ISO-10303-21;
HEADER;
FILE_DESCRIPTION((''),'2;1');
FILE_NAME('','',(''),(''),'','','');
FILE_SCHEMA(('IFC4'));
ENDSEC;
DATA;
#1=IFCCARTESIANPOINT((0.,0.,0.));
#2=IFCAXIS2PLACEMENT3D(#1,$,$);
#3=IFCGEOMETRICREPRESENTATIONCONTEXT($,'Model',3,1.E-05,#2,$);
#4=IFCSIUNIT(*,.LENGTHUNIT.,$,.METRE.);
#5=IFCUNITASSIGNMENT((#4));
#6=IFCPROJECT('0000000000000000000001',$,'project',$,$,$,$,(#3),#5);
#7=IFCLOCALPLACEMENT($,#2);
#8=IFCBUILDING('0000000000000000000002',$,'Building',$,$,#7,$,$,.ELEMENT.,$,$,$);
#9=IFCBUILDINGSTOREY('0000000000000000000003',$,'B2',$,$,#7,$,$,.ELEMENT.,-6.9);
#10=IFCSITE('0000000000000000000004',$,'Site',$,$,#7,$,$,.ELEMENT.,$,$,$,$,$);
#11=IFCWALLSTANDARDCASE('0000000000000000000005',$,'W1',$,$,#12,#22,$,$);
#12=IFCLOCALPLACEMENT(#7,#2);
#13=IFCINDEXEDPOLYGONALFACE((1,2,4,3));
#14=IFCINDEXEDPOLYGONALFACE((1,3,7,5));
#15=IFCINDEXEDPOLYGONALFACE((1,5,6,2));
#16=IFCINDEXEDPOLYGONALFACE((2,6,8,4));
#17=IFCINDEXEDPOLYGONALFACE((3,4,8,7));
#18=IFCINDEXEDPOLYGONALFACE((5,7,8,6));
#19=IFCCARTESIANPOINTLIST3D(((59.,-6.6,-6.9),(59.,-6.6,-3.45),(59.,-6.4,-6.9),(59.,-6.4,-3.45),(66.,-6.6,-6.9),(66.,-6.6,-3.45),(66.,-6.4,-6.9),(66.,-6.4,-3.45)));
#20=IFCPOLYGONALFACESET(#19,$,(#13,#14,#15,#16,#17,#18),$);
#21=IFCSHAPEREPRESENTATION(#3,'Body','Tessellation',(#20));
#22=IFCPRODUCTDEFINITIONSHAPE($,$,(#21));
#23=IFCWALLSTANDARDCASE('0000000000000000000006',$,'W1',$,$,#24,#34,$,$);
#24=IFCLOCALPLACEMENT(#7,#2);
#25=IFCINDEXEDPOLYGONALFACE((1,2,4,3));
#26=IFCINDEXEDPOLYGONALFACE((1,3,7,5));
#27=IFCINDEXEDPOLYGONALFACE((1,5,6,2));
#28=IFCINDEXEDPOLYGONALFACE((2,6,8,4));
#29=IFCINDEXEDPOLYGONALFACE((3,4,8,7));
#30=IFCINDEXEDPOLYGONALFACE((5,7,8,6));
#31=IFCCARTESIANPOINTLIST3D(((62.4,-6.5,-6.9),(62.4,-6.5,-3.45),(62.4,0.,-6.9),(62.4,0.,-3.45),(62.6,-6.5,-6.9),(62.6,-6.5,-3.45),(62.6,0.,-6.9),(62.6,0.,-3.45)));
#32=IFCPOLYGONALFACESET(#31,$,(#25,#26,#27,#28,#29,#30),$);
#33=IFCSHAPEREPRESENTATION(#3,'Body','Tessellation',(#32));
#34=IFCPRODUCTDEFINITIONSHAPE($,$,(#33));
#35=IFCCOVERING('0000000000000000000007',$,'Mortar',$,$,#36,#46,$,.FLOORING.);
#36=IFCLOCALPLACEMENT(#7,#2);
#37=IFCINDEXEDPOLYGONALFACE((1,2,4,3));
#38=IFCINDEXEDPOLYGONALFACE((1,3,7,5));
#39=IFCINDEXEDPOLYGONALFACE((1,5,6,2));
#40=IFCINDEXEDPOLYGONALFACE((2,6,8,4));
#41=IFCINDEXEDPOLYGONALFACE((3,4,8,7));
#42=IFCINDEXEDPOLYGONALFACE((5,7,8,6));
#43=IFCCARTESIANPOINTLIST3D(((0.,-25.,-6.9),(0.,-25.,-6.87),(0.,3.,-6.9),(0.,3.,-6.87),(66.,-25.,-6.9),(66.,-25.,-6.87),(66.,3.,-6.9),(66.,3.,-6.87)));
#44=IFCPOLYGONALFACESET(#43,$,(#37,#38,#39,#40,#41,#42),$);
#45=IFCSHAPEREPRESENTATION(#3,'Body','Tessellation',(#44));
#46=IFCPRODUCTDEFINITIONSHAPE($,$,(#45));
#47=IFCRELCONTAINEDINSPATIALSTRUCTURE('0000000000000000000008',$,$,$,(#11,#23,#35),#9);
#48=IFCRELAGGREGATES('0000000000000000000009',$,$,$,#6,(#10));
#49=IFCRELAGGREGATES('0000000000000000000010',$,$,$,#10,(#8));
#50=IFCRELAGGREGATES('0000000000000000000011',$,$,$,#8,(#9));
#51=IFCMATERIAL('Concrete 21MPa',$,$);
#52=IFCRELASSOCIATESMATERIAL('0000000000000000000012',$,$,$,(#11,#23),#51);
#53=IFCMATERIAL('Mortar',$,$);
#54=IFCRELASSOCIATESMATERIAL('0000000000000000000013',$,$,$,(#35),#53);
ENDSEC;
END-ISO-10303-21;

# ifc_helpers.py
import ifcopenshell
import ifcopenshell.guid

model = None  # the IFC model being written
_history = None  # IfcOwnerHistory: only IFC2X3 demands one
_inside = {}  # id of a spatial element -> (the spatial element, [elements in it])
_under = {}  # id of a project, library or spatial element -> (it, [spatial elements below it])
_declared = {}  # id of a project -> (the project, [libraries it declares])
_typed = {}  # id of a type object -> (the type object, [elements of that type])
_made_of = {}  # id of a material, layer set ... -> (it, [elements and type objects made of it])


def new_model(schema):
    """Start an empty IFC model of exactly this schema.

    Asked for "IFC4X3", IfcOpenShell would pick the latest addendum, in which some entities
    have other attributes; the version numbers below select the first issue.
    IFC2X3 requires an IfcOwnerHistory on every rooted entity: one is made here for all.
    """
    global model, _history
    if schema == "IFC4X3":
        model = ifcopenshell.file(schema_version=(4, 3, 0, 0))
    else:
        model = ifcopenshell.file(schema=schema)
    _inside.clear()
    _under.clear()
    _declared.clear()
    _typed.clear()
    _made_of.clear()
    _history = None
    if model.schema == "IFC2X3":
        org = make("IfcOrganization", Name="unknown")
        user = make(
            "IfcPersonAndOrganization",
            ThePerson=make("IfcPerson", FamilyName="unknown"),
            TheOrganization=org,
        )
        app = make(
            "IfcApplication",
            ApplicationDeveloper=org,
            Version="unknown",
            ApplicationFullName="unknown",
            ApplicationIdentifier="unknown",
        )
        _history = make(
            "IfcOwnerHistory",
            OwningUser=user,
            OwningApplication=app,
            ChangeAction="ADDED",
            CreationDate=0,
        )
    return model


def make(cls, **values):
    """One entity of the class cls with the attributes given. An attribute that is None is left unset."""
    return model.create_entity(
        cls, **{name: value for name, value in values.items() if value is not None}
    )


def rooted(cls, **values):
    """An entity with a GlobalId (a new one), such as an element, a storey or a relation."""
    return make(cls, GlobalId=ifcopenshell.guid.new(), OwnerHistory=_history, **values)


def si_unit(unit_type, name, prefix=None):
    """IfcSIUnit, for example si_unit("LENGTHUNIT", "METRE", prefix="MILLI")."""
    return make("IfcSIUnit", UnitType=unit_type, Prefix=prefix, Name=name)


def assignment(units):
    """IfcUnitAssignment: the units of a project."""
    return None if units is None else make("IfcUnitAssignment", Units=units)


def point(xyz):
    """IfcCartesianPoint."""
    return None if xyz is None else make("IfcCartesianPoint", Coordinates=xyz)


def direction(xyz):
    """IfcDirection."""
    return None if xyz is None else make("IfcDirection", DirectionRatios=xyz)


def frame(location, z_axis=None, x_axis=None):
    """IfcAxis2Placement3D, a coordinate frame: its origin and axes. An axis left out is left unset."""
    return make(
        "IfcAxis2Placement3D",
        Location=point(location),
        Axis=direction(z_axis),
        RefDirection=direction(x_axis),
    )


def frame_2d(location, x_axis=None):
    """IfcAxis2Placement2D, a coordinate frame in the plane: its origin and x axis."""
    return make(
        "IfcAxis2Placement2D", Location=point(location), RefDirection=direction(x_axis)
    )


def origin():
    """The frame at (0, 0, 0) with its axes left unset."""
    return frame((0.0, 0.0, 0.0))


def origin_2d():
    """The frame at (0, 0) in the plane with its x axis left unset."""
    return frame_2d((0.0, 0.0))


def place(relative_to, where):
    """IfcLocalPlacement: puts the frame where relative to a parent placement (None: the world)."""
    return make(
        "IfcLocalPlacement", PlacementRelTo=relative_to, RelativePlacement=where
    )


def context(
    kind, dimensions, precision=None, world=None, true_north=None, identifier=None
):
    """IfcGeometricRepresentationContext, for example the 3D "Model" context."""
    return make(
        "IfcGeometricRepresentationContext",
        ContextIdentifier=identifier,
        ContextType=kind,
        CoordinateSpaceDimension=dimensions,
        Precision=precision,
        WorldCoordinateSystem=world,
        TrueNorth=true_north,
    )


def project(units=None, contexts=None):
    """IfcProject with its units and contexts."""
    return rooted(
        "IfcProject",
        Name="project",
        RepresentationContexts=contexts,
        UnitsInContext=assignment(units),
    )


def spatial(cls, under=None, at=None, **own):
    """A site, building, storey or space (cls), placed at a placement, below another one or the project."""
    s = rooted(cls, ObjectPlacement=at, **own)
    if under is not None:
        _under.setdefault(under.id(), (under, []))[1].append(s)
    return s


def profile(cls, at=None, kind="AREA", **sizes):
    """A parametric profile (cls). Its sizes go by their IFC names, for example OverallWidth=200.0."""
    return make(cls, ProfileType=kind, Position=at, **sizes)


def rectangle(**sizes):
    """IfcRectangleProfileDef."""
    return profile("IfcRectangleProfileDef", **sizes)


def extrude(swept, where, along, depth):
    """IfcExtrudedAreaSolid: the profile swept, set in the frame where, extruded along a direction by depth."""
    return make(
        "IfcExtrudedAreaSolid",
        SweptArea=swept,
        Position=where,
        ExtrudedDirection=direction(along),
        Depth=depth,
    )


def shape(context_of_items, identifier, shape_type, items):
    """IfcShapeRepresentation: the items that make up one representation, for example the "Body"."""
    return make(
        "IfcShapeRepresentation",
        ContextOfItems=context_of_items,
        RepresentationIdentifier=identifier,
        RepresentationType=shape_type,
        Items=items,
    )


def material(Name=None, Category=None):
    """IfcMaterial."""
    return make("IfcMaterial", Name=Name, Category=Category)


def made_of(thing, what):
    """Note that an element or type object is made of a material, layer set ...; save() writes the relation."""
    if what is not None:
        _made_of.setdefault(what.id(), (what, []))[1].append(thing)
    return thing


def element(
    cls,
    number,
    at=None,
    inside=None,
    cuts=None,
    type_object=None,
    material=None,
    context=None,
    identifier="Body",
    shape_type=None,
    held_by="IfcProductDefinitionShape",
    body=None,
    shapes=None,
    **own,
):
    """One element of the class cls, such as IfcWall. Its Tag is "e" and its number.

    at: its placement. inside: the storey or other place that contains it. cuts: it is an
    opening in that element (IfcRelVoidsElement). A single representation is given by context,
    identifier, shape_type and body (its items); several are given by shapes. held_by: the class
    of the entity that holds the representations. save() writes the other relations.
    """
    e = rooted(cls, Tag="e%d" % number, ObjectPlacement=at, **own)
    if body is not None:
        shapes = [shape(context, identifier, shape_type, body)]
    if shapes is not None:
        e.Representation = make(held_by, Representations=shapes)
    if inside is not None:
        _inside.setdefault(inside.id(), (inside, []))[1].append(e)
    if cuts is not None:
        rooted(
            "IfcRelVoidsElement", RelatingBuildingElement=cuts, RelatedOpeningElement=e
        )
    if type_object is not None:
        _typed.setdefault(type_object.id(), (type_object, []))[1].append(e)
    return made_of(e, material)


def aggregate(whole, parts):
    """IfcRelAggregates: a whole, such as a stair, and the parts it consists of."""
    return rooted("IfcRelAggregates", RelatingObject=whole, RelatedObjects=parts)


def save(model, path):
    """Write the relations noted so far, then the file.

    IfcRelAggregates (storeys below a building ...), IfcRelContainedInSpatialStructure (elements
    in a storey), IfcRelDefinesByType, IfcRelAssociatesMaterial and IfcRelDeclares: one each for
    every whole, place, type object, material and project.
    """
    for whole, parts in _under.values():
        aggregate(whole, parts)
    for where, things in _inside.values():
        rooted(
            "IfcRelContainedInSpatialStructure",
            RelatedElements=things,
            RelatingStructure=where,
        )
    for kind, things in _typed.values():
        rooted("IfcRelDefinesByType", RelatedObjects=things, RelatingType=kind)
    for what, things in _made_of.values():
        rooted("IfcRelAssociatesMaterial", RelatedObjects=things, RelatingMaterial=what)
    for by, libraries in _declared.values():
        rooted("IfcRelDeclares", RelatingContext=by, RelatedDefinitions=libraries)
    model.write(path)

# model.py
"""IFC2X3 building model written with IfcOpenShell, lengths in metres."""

from ifc_helpers import new_model, si_unit, frame, origin, origin_2d, place, context, project, spatial, rectangle, extrude, material, element, save


model = new_model("IFC2X3")

# Units and contexts
model_context = context("Model", 3, precision=1e-05, world=origin())
ifc_project = project(units=[si_unit("LENGTHUNIT", "METRE")], contexts=[model_context])

# Site, building, storey
placement = place(None, origin())
site = spatial("IfcSite", under=ifc_project, at=placement, Name="Site", CompositionType="ELEMENT")
building = spatial("IfcBuilding", under=site, at=placement, Name="Building", CompositionType="ELEMENT")
storey = spatial("IfcBuildingStorey", under=building, at=placement, Name="B2", CompositionType="ELEMENT", Elevation=-6.9)

# Shared definitions
ifc_material_1 = material(Name="Concrete 21MPa")

# Walls
wall_1_placement = place(None, frame((62.5, -6.5, -6.9)))
element("IfcWallStandardCase", 1, at=wall_1_placement, inside=storey, material=ifc_material_1, Name="W1", context=model_context, shape_type="SweptSolid", body=[
    extrude(rectangle(XDim=7.0, YDim=0.2, at=origin_2d()), origin(), (0.0, 0.0, 1.0), 3.45),
])
wall_2_placement = place(None, frame((62.5, -3.25, -6.9)))
element("IfcWallStandardCase", 2, at=wall_2_placement, inside=storey, material=ifc_material_1, Name="W1", context=model_context, shape_type="SweptSolid", body=[
    extrude(rectangle(XDim=0.2, YDim=6.5, at=origin_2d()), origin(), (0.0, 0.0, 1.0), 3.45),
])

# Covering
ifc_material_2 = material(Name="Mortar")
covering_placement = place(None, frame((33.0, -11.0, -6.9)))
element("IfcCovering", 3, at=covering_placement, inside=storey, material=ifc_material_2, Name="Mortar", PredefinedType="FLOORING", context=model_context, shape_type="SweptSolid", body=[
    extrude(rectangle(XDim=66.0, YDim=28.0, at=origin_2d()), origin(), (0.0, 0.0, 1.0), 0.03),
])

save(model, "model.ifc")
